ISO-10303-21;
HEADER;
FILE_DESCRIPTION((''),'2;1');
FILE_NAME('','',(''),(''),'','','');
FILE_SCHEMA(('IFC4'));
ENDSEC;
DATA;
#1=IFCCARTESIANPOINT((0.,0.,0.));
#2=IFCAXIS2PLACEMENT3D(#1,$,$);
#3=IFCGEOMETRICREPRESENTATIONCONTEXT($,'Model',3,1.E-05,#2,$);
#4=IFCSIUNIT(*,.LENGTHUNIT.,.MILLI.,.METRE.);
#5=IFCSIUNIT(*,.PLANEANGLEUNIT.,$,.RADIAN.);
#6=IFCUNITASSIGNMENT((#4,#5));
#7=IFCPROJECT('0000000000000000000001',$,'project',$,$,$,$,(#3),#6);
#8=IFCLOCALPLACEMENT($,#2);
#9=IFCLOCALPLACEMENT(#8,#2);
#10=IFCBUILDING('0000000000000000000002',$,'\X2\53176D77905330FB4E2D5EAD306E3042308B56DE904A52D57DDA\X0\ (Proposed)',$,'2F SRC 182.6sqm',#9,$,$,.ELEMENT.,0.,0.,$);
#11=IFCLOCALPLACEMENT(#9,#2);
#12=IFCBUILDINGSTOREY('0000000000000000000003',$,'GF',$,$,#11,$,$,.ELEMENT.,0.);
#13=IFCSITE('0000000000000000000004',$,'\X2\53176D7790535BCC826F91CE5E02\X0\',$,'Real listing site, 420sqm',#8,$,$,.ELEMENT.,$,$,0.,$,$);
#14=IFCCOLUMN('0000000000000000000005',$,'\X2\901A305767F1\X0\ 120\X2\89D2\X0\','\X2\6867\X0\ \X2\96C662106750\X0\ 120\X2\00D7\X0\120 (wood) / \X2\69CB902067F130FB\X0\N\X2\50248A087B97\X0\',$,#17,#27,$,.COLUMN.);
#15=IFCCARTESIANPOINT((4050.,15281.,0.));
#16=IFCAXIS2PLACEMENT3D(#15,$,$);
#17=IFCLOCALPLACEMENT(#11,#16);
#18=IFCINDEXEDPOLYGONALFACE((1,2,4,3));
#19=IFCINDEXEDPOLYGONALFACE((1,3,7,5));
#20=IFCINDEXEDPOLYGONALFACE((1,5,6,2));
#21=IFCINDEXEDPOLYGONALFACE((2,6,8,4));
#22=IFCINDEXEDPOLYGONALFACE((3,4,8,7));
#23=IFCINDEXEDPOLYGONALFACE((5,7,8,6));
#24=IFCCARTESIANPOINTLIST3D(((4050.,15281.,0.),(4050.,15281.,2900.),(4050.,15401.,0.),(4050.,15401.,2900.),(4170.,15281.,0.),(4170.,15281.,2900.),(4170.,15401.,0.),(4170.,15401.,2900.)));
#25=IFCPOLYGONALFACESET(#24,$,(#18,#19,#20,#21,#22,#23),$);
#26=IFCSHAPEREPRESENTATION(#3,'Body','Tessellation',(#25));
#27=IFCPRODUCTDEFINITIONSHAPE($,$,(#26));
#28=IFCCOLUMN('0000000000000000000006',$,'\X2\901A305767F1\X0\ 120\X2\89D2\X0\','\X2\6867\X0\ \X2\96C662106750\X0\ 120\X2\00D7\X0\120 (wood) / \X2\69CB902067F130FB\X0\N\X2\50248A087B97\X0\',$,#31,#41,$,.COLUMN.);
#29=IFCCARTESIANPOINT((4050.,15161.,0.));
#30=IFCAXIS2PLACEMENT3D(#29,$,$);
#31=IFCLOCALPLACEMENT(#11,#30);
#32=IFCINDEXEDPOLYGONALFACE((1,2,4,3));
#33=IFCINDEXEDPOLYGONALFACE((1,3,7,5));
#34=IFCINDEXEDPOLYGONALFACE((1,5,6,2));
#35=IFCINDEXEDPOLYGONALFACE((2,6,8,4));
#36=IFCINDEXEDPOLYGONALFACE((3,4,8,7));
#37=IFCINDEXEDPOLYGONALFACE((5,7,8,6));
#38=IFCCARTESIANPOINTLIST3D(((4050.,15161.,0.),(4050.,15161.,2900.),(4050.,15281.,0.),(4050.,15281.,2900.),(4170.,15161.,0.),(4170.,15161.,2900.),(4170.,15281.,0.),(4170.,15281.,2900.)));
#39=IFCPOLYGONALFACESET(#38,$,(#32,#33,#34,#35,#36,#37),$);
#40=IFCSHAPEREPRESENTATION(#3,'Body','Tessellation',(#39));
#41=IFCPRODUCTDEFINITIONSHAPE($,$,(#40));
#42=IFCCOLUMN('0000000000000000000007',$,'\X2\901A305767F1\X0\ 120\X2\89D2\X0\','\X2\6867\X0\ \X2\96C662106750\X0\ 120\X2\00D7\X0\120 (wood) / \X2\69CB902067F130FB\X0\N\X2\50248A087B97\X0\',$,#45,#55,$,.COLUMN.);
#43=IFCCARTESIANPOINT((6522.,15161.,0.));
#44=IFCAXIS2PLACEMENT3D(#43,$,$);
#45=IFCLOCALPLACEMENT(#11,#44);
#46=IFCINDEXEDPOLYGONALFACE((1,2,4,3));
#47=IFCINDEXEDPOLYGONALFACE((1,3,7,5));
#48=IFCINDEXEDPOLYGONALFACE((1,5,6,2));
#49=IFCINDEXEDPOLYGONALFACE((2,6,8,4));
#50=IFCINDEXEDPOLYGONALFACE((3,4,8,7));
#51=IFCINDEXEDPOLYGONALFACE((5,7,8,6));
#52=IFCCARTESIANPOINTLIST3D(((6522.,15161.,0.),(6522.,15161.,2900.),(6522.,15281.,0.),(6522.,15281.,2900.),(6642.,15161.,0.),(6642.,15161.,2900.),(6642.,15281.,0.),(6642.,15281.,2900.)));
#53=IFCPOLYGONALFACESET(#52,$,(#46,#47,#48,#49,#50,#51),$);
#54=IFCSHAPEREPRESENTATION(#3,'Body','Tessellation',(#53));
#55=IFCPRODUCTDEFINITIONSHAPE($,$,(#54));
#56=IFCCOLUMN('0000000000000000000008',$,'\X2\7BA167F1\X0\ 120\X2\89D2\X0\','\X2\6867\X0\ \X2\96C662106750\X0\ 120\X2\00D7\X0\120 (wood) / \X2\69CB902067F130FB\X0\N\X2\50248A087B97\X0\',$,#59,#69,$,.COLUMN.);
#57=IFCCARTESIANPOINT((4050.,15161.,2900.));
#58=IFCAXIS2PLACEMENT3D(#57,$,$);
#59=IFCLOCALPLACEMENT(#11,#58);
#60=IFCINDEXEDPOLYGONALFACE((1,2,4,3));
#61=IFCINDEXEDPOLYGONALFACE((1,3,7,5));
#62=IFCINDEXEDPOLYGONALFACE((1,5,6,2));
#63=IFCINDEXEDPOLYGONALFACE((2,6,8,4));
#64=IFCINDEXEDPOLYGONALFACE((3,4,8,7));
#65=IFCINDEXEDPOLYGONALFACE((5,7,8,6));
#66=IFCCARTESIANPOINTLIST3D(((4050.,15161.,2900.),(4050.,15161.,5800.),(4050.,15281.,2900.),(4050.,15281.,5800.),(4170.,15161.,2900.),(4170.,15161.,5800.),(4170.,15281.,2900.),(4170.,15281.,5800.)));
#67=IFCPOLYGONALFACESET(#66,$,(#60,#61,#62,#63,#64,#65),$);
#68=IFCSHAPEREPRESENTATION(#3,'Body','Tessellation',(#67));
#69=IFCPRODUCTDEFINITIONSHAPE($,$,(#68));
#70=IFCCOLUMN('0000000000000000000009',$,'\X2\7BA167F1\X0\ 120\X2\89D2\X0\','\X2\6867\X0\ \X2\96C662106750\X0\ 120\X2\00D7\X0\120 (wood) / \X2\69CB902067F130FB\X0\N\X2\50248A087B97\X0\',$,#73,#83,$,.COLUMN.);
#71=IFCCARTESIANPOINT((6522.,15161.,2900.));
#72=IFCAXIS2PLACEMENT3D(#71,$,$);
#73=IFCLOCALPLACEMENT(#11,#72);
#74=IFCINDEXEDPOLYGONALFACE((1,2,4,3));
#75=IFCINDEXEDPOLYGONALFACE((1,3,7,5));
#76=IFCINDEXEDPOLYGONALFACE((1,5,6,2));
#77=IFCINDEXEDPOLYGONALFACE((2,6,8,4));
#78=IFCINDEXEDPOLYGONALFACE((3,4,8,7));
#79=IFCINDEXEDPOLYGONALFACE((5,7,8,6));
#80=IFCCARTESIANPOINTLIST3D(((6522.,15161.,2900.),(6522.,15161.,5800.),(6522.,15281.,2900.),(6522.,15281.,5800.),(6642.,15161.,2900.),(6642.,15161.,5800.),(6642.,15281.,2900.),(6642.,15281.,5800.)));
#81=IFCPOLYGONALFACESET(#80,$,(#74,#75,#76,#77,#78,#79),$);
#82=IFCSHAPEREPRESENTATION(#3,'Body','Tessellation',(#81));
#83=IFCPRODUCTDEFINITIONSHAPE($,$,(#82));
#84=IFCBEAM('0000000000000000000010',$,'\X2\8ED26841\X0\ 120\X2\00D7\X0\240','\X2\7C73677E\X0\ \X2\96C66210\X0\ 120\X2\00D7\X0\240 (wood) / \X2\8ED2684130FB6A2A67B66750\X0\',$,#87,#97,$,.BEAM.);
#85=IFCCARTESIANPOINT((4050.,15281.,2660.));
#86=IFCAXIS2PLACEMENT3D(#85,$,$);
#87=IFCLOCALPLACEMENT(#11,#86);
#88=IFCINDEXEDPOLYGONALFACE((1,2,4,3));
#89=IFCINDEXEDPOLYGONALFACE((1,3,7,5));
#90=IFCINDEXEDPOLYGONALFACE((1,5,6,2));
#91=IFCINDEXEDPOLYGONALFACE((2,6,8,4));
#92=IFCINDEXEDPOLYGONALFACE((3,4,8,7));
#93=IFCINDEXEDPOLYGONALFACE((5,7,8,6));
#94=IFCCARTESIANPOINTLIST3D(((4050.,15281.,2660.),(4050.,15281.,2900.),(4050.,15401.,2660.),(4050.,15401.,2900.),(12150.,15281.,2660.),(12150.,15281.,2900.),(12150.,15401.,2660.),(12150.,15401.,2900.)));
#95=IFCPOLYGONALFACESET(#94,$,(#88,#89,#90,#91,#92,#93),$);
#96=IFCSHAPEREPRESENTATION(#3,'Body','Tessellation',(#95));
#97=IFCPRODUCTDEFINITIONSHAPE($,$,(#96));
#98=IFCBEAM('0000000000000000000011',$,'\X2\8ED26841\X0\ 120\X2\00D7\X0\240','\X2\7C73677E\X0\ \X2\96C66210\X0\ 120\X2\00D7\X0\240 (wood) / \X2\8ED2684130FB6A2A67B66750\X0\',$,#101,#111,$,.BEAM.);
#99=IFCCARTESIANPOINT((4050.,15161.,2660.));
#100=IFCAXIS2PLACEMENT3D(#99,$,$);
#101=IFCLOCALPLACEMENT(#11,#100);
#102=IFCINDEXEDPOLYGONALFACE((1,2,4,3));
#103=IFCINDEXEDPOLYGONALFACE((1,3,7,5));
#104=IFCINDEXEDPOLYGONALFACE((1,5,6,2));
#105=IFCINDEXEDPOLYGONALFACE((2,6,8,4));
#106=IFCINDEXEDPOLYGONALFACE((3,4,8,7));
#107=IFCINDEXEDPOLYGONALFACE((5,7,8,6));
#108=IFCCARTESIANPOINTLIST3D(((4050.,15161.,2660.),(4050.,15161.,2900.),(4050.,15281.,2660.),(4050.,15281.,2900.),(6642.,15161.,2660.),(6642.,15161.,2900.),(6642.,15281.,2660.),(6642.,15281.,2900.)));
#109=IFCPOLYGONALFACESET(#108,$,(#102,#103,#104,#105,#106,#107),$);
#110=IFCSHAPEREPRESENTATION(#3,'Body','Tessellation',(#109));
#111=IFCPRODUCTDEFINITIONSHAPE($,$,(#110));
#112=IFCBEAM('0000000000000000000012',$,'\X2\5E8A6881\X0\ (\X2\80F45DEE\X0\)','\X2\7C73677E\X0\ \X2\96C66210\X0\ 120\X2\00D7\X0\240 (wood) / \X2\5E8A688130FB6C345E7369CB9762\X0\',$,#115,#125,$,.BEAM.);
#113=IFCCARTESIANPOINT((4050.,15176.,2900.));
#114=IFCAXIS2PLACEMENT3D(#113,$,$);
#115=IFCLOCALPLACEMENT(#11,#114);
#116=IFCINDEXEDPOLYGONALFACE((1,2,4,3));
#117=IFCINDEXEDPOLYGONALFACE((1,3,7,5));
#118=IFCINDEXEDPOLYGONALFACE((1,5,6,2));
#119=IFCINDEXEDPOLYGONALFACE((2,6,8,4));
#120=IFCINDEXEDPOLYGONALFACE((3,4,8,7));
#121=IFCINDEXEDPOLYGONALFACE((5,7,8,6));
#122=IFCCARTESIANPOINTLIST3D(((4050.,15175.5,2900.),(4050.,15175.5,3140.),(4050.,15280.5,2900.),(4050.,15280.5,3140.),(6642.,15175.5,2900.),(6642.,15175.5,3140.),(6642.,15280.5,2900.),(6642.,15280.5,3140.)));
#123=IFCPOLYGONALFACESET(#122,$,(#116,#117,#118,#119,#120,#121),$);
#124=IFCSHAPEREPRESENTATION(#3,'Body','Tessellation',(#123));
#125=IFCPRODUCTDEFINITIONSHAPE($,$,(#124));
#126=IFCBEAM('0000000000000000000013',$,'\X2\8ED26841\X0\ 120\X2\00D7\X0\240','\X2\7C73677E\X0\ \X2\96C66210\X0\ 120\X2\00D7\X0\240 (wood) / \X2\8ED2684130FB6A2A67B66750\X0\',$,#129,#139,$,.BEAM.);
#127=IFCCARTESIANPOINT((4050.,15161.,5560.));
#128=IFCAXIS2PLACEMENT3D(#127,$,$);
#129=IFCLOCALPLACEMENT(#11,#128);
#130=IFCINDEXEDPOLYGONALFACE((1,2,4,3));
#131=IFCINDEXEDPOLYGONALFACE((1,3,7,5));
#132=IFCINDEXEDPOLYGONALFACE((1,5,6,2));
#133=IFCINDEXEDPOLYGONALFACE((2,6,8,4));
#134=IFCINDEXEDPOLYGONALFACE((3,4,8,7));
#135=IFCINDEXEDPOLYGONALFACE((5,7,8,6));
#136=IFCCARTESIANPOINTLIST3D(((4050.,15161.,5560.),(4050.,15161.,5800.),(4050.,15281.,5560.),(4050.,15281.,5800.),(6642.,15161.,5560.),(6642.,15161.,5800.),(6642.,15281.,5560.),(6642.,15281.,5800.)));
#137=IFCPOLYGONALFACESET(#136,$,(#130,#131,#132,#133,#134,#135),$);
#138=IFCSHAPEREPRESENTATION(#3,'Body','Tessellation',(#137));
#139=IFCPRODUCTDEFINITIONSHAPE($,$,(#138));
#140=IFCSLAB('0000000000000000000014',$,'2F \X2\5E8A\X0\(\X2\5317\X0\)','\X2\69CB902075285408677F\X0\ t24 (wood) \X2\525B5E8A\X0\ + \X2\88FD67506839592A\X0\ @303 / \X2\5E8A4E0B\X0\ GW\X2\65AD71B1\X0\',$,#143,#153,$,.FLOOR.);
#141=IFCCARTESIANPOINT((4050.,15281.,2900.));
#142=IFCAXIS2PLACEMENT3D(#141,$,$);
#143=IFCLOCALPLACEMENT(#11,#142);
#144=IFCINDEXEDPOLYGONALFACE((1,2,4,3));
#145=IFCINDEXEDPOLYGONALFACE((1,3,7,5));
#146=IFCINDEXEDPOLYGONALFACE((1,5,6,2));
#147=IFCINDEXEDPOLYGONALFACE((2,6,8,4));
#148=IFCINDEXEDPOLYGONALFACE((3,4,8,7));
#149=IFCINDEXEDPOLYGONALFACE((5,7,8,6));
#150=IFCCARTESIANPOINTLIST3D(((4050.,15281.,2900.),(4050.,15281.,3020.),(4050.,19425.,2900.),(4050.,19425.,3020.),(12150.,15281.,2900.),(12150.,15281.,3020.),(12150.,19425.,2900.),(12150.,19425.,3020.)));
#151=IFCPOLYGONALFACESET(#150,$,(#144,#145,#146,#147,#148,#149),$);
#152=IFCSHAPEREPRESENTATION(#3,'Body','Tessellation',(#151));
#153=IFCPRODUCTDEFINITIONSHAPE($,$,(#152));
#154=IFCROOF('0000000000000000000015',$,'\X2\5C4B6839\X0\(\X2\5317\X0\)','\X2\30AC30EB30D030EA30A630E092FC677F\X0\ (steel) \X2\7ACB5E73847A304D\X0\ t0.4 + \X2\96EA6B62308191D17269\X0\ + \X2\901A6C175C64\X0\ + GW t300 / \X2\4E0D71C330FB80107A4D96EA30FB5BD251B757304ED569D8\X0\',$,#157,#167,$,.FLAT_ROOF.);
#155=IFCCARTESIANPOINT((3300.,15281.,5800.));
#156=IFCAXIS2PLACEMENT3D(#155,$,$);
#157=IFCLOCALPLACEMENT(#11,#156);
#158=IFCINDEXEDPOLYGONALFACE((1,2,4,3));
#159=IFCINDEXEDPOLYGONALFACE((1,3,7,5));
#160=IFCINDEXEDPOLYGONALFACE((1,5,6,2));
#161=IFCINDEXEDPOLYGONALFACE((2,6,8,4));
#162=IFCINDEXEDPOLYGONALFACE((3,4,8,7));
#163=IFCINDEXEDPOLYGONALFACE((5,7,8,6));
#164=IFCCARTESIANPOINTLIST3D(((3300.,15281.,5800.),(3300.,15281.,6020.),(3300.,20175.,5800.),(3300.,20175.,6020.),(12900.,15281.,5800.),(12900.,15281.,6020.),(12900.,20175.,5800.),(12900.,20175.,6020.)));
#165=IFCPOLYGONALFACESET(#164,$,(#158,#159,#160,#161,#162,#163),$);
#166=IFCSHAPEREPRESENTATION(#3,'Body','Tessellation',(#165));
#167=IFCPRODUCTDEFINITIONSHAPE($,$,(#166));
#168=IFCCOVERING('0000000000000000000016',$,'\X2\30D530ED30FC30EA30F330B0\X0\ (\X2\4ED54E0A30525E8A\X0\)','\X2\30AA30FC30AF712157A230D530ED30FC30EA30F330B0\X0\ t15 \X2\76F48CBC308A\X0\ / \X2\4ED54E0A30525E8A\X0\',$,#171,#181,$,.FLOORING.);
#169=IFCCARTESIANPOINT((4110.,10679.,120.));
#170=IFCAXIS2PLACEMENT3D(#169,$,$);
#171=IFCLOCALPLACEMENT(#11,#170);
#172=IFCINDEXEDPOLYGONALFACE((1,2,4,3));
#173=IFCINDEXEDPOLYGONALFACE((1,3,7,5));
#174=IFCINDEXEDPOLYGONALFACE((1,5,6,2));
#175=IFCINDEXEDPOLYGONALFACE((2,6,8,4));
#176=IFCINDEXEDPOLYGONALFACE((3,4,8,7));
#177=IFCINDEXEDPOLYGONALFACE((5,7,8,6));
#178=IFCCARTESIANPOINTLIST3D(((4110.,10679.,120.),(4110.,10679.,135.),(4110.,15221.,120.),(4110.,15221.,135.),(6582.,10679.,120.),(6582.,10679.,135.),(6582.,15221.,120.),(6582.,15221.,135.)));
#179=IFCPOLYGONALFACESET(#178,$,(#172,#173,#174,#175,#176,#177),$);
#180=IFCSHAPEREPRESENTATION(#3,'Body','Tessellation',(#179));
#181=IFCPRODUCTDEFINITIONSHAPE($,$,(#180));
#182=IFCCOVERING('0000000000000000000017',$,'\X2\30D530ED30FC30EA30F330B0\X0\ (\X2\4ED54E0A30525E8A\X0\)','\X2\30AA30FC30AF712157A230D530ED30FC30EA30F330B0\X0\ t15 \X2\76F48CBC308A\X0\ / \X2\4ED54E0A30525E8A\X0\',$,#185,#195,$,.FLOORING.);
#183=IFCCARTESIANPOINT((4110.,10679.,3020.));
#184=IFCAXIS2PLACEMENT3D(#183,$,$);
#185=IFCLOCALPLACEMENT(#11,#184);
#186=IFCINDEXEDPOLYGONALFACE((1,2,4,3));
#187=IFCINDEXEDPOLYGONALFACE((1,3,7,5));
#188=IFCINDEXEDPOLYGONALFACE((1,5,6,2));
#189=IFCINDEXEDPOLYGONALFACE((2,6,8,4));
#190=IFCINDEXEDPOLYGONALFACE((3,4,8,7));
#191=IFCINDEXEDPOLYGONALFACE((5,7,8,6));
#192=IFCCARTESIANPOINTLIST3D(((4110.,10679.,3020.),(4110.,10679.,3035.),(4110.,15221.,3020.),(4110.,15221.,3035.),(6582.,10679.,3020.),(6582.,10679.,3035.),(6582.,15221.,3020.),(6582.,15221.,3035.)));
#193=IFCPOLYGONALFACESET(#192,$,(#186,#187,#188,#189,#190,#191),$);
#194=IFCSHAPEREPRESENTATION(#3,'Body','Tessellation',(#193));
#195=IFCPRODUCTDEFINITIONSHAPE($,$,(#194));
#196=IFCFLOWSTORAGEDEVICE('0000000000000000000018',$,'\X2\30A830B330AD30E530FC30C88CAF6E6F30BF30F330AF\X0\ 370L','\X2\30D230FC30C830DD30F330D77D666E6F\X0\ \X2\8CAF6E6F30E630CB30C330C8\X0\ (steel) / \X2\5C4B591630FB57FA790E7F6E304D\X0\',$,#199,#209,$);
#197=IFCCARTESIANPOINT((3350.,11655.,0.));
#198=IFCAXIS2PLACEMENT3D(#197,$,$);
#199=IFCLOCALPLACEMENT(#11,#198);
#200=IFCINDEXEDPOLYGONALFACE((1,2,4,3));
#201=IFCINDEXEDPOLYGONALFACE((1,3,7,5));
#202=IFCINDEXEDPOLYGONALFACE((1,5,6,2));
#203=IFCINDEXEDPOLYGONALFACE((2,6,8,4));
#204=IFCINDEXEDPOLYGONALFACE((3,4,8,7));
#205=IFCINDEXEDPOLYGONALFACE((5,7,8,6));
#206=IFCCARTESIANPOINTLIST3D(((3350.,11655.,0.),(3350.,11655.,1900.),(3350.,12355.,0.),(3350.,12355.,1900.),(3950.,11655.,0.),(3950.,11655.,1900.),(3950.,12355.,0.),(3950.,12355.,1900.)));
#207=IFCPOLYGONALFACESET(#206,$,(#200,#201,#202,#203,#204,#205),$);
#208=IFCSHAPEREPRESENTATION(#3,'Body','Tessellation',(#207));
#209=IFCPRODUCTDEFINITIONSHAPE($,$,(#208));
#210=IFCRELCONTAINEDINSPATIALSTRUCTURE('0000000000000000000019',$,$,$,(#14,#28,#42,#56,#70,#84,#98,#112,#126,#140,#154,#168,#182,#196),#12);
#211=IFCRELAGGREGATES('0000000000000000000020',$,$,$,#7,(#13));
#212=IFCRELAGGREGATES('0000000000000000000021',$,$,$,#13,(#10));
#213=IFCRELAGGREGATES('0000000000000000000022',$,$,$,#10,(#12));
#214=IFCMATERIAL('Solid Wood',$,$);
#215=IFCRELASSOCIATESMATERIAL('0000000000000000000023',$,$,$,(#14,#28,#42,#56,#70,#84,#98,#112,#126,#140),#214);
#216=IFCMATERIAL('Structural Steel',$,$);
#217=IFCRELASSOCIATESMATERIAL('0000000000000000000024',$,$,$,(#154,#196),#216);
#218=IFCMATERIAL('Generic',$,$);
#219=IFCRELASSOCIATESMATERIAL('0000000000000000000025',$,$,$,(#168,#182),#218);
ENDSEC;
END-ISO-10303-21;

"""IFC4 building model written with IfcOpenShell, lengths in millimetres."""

from ifc_helpers import new_model, si_unit, frame, frame_2d, origin, place, context, project, spatial, rectangle, extrude, material, element, save


model = new_model("IFC4")

# Units and contexts
model_context = context("Model", 3, precision=1e-05, world=origin())
ifc_project = project(units=[si_unit("LENGTHUNIT", "METRE", prefix="MILLI"), si_unit("PLANEANGLEUNIT", "RADIAN")], contexts=[model_context])

# Site, building, storey
site_placement = place(None, origin())
site = spatial("IfcSite", under=ifc_project, at=site_placement, Name="北海道富良野市", ObjectType="Real listing site, 420sqm", CompositionType="ELEMENT", RefElevation=0.0)
building_placement = place(site_placement, origin())
building = spatial("IfcBuilding", under=site, at=building_placement, Name="北海道・中庭のある回遊動線 (Proposed)", ObjectType="2F SRC 182.6sqm", CompositionType="ELEMENT", ElevationOfRefHeight=0.0, ElevationOfTerrain=0.0)
storey_placement = place(building_placement, origin())
storey = spatial("IfcBuildingStorey", under=building, at=storey_placement, Name="GF", CompositionType="ELEMENT", Elevation=0.0)

# Columns
ifc_material_1 = material(Name="Solid Wood")
column_1_placement = place(storey_placement, frame((4050.0, 15281.0, 0.0)))
element("IfcColumn", 1, at=column_1_placement, inside=storey, material=ifc_material_1, Name="通し柱 120角", Description="桧 集成材 120×120 (wood) / 構造柱・N値計算", PredefinedType="COLUMN", context=model_context, shape_type="SweptSolid", body=[
    extrude(rectangle(XDim=120.0, YDim=120.0, at=frame_2d((60.0, 60.0))), frame((4050.0, 15281.0, 0.0)), (0.0, 0.0, 1.0), 2900.0),
])
column_2_placement = place(storey_placement, frame((4050.0, 15161.0, 0.0)))
element("IfcColumn", 2, at=column_2_placement, inside=storey, material=ifc_material_1, Name="通し柱 120角", Description="桧 集成材 120×120 (wood) / 構造柱・N値計算", PredefinedType="COLUMN", context=model_context, shape_type="SweptSolid", body=[
    extrude(rectangle(XDim=120.0, YDim=120.0, at=frame_2d((60.0, 60.0))), frame((4050.0, 15161.0, 0.0)), (0.0, 0.0, 1.0), 2900.0),
])
column_3_placement = place(storey_placement, frame((6522.0, 15161.0, 0.0)))
element("IfcColumn", 3, at=column_3_placement, inside=storey, material=ifc_material_1, Name="通し柱 120角", Description="桧 集成材 120×120 (wood) / 構造柱・N値計算", PredefinedType="COLUMN", context=model_context, shape_type="SweptSolid", body=[
    extrude(rectangle(XDim=120.0, YDim=120.0, at=frame_2d((60.0, 60.0))), frame((6522.0, 15161.0, 0.0)), (0.0, 0.0, 1.0), 2900.0),
])
column_4_placement = place(storey_placement, frame((4050.0, 15161.0, 2900.0)))
element("IfcColumn", 4, at=column_4_placement, inside=storey, material=ifc_material_1, Name="管柱 120角", Description="桧 集成材 120×120 (wood) / 構造柱・N値計算", PredefinedType="COLUMN", context=model_context, shape_type="SweptSolid", body=[
    extrude(rectangle(XDim=120.0, YDim=120.0, at=frame_2d((60.0, 60.0))), frame((4050.0, 15161.0, 2900.0)), (0.0, 0.0, 1.0), 2900.0),
])
column_5_placement = place(storey_placement, frame((6522.0, 15161.0, 2900.0)))
element("IfcColumn", 5, at=column_5_placement, inside=storey, material=ifc_material_1, Name="管柱 120角", Description="桧 集成材 120×120 (wood) / 構造柱・N値計算", PredefinedType="COLUMN", context=model_context, shape_type="SweptSolid", body=[
    extrude(rectangle(XDim=120.0, YDim=120.0, at=frame_2d((60.0, 60.0))), frame((6522.0, 15161.0, 2900.0)), (0.0, 0.0, 1.0), 2900.0),
])

# Beams
beam_1_placement = place(storey_placement, frame((4050.0, 15281.0, 2660.0)))
element("IfcBeam", 6, at=beam_1_placement, inside=storey, material=ifc_material_1, Name="軒桁 120×240", Description="米松 集成 120×240 (wood) / 軒桁・横架材", PredefinedType="BEAM", context=model_context, shape_type="SweptSolid", body=[
    extrude(rectangle(XDim=8100.0, YDim=120.0, at=frame_2d((4050.0, 60.0))), frame((4050.0, 15281.0, 2660.0)), (0.0, 0.0, 1.0), 240.0),
])
beam_2_placement = place(storey_placement, frame((4050.0, 15161.0, 2660.0)))
element("IfcBeam", 7, at=beam_2_placement, inside=storey, material=ifc_material_1, Name="軒桁 120×240", Description="米松 集成 120×240 (wood) / 軒桁・横架材", PredefinedType="BEAM", context=model_context, shape_type="SweptSolid", body=[
    extrude(rectangle(XDim=2592.0, YDim=120.0, at=frame_2d((1296.0, 60.0))), frame((4050.0, 15161.0, 2660.0)), (0.0, 0.0, 1.0), 240.0),
])
beam_3_placement = place(storey_placement, frame((4050.0, 15176.0, 2900.0)))
element("IfcBeam", 8, at=beam_3_placement, inside=storey, material=ifc_material_1, Name="床梁 (胴差)", Description="米松 集成 120×240 (wood) / 床梁・水平構面", PredefinedType="BEAM", context=model_context, shape_type="SweptSolid", body=[
    extrude(rectangle(XDim=2592.0, YDim=105.0, at=frame_2d((1296.0, 52.0))), frame((4050.0, 15176.0, 2900.0)), (0.0, 0.0, 1.0), 240.0),
])
beam_4_placement = place(storey_placement, frame((4050.0, 15161.0, 5560.0)))
element("IfcBeam", 9, at=beam_4_placement, inside=storey, material=ifc_material_1, Name="軒桁 120×240", Description="米松 集成 120×240 (wood) / 軒桁・横架材", PredefinedType="BEAM", context=model_context, shape_type="SweptSolid", body=[
    extrude(rectangle(XDim=2592.0, YDim=120.0, at=frame_2d((1296.0, 60.0))), frame((4050.0, 15161.0, 5560.0)), (0.0, 0.0, 1.0), 240.0),
])

# Slab
slab_1_placement = place(storey_placement, frame((4050.0, 15281.0, 2900.0)))
element("IfcSlab", 10, at=slab_1_placement, inside=storey, material=ifc_material_1, Name="2F 床(北)", Description="構造用合板 t24 (wood) 剛床 + 製材根太 @303 / 床下 GW断熱", PredefinedType="FLOOR", context=model_context, shape_type="SweptSolid", body=[
    extrude(rectangle(XDim=8100.0, YDim=4144.0, at=frame_2d((4050.0, 2072.0))), frame((4050.0, 15281.0, 2900.0)), (0.0, 0.0, 1.0), 120.0),
])

# Roof
ifc_material_2 = material(Name="Structural Steel")
for number, where, name in (
    (11, (3300.0, 15281.0, 5800.0), "屋根(北)"),
):
    element("IfcRoof", number, at=place(storey_placement, frame(where)), inside=storey, material=ifc_material_2, Name=name, Description="ガルバリウム鋼板 (steel) 立平葺き t0.4 + 雪止め金物 + 通気層 + GW t300 / 不燃・耐積雪・寒冷地仕様", PredefinedType="FLAT_ROOF", context=model_context, shape_type="SweptSolid", body=[
        extrude(rectangle(XDim=9600.0, YDim=4894.0, at=frame_2d((4800.0, 2447.0))), frame((3300.0, 15281.0, 5800.0)), (0.0, 0.0, 1.0), 220.0),
    ])

# Coverings
ifc_material_3 = material(Name="Generic")
covering_1_placement = place(storey_placement, frame((4110.0, 10679.0, 120.0)))
element("IfcCovering", 12, at=covering_1_placement, inside=storey, material=ifc_material_3, Name="フローリング (仕上げ床)", Description="オーク無垢フローリング t15 直貼り / 仕上げ床", PredefinedType="FLOORING", context=model_context, shape_type="SweptSolid", body=[
    extrude(rectangle(XDim=2472.0, YDim=4542.0, at=frame_2d((1236.0, 2271.0))), frame((4110.0, 10679.0, 120.0)), (0.0, 0.0, 1.0), 15.0),
])
covering_2_placement = place(storey_placement, frame((4110.0, 10679.0, 3020.0)))
element("IfcCovering", 13, at=covering_2_placement, inside=storey, material=ifc_material_3, Name="フローリング (仕上げ床)", Description="オーク無垢フローリング t15 直貼り / 仕上げ床", PredefinedType="FLOORING", context=model_context, shape_type="SweptSolid", body=[
    extrude(rectangle(XDim=2472.0, YDim=4542.0, at=frame_2d((1236.0, 2271.0))), frame((4110.0, 10679.0, 3020.0)), (0.0, 0.0, 1.0), 15.0),
])

# Flow storage device
flow_storage_device_placement = place(storey_placement, frame((3350.0, 11655.0, 0.0)))
element("IfcFlowStorageDevice", 14, at=flow_storage_device_placement, inside=storey, material=ifc_material_2, Name="エコキュート貯湯タンク 370L", Description="ヒートポンプ給湯 貯湯ユニット (steel) / 屋外・基礎置き", context=model_context, shape_type="SweptSolid", body=[
    extrude(rectangle(XDim=600.0, YDim=700.0, at=frame_2d((300.0, 350.0))), frame((3350.0, 11655.0, 0.0)), (0.0, 0.0, 1.0), 1900.0),
])

save(model, "model.ifc")
